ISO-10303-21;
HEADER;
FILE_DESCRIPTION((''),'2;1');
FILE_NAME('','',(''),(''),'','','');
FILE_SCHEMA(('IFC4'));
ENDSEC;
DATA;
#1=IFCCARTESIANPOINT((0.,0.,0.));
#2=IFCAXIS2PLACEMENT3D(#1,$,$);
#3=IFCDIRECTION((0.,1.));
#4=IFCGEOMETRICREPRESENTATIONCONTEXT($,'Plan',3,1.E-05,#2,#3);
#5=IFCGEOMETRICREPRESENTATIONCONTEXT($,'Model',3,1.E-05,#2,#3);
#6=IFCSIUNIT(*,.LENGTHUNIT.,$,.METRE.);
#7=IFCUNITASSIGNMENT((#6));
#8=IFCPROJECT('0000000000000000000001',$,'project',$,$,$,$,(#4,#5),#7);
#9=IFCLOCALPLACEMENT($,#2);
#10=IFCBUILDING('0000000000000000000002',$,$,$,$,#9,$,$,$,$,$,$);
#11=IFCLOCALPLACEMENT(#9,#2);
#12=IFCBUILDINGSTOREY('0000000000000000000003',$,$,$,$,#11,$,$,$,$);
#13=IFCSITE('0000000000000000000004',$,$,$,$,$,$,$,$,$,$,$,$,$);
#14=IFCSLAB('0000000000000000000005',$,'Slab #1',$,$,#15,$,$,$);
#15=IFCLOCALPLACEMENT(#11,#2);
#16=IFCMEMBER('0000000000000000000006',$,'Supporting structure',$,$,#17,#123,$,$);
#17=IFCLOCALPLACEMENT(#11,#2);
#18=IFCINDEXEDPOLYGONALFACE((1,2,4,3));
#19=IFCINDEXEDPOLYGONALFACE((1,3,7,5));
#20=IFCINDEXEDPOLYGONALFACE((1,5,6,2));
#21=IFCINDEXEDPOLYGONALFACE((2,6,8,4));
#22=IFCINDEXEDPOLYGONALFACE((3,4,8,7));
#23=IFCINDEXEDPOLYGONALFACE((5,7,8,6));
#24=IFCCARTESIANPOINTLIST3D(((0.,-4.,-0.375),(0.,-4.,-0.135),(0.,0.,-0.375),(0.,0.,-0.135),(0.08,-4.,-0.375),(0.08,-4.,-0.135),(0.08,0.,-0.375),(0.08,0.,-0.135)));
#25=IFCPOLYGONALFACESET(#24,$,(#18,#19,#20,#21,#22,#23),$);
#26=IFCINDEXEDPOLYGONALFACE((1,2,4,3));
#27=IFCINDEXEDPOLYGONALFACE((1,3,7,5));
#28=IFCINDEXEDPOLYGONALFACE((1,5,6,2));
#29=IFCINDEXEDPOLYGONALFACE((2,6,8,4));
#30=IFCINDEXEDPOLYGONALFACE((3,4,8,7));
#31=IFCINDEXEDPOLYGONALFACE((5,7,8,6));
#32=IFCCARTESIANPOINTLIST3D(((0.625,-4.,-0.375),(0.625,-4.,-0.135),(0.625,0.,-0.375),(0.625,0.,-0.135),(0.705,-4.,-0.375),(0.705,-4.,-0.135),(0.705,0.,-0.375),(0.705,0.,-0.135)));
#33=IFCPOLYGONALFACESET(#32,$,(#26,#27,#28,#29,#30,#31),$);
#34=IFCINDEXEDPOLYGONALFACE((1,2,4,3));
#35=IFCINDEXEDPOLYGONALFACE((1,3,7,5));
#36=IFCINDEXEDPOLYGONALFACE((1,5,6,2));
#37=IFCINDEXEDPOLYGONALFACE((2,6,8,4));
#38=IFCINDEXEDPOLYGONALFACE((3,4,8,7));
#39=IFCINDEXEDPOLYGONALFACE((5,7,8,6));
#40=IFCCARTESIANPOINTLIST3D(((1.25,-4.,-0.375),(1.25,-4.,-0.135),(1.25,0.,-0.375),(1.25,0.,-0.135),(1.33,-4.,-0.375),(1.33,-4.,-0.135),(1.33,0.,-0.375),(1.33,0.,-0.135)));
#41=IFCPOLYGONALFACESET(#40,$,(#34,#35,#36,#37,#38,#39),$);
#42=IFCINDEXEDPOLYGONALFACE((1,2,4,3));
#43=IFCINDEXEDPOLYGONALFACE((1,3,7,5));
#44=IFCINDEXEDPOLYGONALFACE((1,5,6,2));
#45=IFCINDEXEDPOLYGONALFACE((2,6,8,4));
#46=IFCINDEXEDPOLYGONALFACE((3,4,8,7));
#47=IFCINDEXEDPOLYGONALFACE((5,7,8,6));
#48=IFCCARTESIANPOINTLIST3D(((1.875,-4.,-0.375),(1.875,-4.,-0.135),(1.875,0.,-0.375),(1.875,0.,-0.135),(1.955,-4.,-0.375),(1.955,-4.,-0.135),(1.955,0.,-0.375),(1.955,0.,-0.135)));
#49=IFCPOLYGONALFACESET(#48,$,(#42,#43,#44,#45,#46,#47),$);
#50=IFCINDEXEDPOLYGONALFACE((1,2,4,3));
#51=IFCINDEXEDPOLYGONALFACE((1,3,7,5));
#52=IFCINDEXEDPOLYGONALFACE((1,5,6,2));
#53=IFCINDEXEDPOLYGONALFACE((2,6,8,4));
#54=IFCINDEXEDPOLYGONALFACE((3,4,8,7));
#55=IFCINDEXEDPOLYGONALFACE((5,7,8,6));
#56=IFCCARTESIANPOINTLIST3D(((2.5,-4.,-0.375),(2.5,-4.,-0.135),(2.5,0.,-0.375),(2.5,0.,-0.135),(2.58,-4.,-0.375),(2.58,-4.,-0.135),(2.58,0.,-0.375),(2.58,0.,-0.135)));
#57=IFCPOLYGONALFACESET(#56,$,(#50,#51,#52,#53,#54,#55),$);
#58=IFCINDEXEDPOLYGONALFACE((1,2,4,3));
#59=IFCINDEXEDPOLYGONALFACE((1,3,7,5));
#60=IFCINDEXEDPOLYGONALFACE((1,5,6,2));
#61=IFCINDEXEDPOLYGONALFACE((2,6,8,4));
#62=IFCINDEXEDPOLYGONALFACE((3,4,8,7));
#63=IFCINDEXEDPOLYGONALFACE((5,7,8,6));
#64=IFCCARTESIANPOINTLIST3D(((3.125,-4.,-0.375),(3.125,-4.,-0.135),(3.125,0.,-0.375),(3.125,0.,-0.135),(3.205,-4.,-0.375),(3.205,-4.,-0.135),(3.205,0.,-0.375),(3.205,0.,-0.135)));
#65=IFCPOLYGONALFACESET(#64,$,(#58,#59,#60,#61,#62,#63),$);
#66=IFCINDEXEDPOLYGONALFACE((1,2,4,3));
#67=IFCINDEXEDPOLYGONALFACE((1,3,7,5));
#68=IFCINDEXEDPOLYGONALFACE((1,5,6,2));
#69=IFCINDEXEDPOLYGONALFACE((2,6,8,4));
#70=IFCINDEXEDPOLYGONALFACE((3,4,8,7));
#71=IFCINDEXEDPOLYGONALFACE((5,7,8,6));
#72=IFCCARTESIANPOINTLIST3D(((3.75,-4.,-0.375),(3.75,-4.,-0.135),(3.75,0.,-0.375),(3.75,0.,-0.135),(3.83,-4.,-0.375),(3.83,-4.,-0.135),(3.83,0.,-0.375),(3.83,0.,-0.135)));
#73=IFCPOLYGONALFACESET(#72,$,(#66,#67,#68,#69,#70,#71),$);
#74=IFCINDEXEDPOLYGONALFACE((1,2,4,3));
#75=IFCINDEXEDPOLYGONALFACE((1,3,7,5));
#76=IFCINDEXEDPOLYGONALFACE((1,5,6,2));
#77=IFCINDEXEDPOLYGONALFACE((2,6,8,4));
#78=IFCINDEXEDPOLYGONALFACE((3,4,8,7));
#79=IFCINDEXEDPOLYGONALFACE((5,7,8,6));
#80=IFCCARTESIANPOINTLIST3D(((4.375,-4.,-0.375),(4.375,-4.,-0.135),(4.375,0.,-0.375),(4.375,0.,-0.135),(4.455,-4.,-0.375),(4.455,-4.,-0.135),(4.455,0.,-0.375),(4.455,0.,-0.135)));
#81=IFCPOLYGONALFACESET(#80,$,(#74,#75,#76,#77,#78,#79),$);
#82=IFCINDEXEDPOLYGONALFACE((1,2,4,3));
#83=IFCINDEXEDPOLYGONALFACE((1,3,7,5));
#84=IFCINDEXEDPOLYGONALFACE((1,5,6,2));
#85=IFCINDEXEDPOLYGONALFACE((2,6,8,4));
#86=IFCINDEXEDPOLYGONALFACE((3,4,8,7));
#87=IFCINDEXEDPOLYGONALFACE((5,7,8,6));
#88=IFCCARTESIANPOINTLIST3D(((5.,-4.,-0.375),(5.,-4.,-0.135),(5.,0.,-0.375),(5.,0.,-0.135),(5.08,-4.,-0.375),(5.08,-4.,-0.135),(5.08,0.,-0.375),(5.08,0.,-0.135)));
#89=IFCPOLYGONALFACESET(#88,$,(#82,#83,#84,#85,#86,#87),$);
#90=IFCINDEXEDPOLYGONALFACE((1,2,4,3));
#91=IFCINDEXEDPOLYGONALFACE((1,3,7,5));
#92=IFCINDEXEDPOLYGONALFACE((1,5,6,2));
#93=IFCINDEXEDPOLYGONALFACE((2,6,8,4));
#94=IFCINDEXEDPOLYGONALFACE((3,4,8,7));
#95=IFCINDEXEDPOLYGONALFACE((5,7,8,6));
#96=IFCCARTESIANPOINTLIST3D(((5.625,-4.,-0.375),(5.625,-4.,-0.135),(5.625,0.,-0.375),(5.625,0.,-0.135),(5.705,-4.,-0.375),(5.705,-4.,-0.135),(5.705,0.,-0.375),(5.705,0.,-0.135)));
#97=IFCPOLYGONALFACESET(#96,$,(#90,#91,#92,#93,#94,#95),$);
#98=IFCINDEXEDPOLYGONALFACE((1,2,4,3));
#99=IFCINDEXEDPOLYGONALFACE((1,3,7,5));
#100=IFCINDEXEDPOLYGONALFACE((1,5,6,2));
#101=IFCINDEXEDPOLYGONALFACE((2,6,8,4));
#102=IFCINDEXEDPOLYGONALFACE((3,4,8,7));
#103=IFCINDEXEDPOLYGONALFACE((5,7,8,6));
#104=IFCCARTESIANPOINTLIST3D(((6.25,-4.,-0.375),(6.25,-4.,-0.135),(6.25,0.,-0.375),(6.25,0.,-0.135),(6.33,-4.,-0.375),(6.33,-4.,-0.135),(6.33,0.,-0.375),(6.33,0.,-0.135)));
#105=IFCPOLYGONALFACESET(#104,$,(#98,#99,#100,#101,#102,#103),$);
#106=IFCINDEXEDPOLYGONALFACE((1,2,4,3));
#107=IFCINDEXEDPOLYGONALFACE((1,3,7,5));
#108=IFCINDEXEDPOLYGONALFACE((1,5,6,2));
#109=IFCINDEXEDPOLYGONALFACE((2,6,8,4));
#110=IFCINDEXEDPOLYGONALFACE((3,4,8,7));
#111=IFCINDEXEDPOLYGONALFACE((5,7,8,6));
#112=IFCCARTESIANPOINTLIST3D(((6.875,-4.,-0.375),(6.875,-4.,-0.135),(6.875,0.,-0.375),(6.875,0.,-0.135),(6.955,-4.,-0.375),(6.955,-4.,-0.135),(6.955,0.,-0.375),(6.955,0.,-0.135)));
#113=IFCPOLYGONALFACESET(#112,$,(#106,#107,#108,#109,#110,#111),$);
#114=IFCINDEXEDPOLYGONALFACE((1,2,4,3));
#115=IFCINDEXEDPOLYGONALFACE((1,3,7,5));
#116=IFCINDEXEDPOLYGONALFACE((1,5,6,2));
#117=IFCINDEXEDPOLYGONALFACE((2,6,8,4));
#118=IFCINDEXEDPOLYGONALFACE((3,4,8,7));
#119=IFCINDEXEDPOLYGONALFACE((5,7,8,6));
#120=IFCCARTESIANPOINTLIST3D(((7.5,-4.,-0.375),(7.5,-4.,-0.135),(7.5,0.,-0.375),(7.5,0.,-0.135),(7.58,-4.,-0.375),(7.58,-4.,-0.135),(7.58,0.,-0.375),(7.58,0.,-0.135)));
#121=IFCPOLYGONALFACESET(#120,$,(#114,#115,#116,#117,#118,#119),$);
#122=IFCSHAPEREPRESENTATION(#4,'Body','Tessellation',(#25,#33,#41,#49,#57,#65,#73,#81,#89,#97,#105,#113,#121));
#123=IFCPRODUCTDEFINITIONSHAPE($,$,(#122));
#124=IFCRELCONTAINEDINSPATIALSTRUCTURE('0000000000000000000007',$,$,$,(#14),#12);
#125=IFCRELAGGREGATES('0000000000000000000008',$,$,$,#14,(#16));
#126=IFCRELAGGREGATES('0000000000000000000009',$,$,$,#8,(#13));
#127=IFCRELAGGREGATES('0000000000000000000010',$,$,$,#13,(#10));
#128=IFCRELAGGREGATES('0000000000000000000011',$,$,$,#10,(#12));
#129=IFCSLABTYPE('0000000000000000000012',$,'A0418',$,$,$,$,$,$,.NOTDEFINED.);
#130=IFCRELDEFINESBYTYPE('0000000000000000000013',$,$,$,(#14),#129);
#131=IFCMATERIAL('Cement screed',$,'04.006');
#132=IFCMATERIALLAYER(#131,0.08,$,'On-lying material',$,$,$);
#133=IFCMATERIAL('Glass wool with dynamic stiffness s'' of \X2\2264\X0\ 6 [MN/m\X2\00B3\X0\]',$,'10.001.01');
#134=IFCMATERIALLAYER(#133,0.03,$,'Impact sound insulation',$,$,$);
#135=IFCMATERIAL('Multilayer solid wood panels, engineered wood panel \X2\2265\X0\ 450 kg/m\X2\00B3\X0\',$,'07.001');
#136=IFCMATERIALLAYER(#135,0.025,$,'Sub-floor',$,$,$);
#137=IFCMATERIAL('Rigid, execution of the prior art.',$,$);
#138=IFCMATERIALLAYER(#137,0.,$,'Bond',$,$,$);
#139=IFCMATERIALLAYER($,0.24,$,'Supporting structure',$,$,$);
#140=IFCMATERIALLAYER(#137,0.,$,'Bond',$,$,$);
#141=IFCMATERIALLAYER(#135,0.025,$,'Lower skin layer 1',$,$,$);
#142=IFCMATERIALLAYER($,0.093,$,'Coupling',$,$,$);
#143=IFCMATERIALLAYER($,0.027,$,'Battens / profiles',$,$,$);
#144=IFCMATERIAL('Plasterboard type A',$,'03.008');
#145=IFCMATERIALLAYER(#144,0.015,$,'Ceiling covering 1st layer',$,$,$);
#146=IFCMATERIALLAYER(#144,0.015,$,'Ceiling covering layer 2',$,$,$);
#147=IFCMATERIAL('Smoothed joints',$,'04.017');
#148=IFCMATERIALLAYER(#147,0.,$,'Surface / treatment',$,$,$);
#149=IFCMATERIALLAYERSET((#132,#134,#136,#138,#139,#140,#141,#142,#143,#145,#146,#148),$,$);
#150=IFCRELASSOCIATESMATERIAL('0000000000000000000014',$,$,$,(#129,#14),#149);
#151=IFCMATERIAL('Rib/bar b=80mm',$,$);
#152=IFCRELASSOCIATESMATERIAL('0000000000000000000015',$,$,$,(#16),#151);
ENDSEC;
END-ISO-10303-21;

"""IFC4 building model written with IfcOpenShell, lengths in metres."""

from ifc_helpers import new_model, si_unit, direction, frame, frame_2d, origin, place, context, project, spatial, rectangle, extrude, material, layer, layer_set, type_object, element, aggregate, save


model = new_model("IFC4")

# Units and contexts
plan_context = context("Plan", 3, precision=1e-05, world=origin(), true_north=direction((0.0, 1.0)))
model_context = context("Model", 3, precision=1e-05, world=origin(), true_north=direction((0.0, 1.0)))
ifc_project = project(units=[si_unit("LENGTHUNIT", "METRE")], contexts=[plan_context, model_context])

# Site, building, storey
site = spatial("IfcSite", under=ifc_project)
building_placement = place(None, origin())
building = spatial("IfcBuilding", under=site, at=building_placement)
storey_placement = place(building_placement, origin())
storey = spatial("IfcBuildingStorey", under=building, at=storey_placement)

# Slab, member
ifc_material_1 = material(Name="Cement screed", Category="04.006")
ifc_layer_1 = layer(ifc_material_1, 0.08, Name="On-lying material")
ifc_material_2 = material(Name="Glass wool with dynamic stiffness s' of ≤ 6 [MN/m³]", Category="10.001.01")
ifc_layer_2 = layer(ifc_material_2, 0.03, Name="Impact sound insulation")
ifc_material_3 = material(Name="Multilayer solid wood panels, engineered wood panel ≥ 450 kg/m³", Category="07.001")
ifc_layer_3 = layer(ifc_material_3, 0.025, Name="Sub-floor")
ifc_material_4 = material(Name="Rigid, execution of the prior art.")
ifc_layer_4 = layer(ifc_material_4, 0.0, Name="Bond")
ifc_layer_5 = layer(None, 0.24, Name="Supporting structure")
ifc_layer_6 = layer(ifc_material_4, 0.0, Name="Bond")
ifc_layer_7 = layer(ifc_material_3, 0.025, Name="Lower skin layer 1")
ifc_layer_8 = layer(None, 0.093, Name="Coupling")
ifc_layer_9 = layer(None, 0.027, Name="Battens / profiles")
ifc_material_5 = material(Name="Plasterboard type A", Category="03.008")
ifc_layer_10 = layer(ifc_material_5, 0.015, Name="Ceiling covering 1st layer")
ifc_layer_11 = layer(ifc_material_5, 0.015, Name="Ceiling covering layer 2")
ifc_material_6 = material(Name="Smoothed joints", Category="04.017")
ifc_layer_12 = layer(ifc_material_6, 0.0, Name="Surface / treatment")
ifc_layer_set = layer_set([ifc_layer_1, ifc_layer_2, ifc_layer_3, ifc_layer_4, ifc_layer_5, ifc_layer_6, ifc_layer_7, ifc_layer_8, ifc_layer_9, ifc_layer_10, ifc_layer_11, ifc_layer_12])
slab_type = type_object("IfcSlabType", Name="A0418", PredefinedType="NOTDEFINED", material=ifc_layer_set)
slab_placement = place(None, frame((0.0, 0.0, 0.0), z_axis=(0.0, 0.0, -1.0), x_axis=(1.0, 0.0, 0.0)))
slab = element("IfcSlab", 1, at=slab_placement, inside=storey, type_object=slab_type, material=ifc_layer_set, Name="Slab #1")
ifc_material_7 = material(Name="Rib/bar b=80mm")
member_1_placement = place(slab_placement, origin())
member_1 = element("IfcMember", 2, at=member_1_placement, material=ifc_material_7, Name="Supporting structure", context=plan_context, shape_type="SweptSolid", body=[
    extrude(rectangle(XDim=0.08, YDim=0.24, at=frame_2d((0.04, 0.12), x_axis=(1.0, 0.0))), frame((0.0, 4.0, 0.135), z_axis=(0.0, -1.0, 0.0), x_axis=(1.0, 0.0, 0.0)), (0.0, 0.0, 1.0), 4.0),
    extrude(rectangle(XDim=0.08, YDim=0.24, at=frame_2d((0.04, 0.12), x_axis=(1.0, 0.0))), frame((0.625, 4.0, 0.135), z_axis=(0.0, -1.0, 0.0), x_axis=(1.0, 0.0, 0.0)), (0.0, 0.0, 1.0), 4.0),
    extrude(rectangle(XDim=0.08, YDim=0.24, at=frame_2d((0.04, 0.12), x_axis=(1.0, 0.0))), frame((1.25, 4.0, 0.135), z_axis=(0.0, -1.0, 0.0), x_axis=(1.0, 0.0, 0.0)), (0.0, 0.0, 1.0), 4.0),
    extrude(rectangle(XDim=0.08, YDim=0.24, at=frame_2d((0.04, 0.12), x_axis=(1.0, 0.0))), frame((1.875, 4.0, 0.135), z_axis=(0.0, -1.0, 0.0), x_axis=(1.0, 0.0, 0.0)), (0.0, 0.0, 1.0), 4.0),
    extrude(rectangle(XDim=0.08, YDim=0.24, at=frame_2d((0.04, 0.12), x_axis=(1.0, 0.0))), frame((2.5, 4.0, 0.135), z_axis=(0.0, -1.0, 0.0), x_axis=(1.0, 0.0, 0.0)), (0.0, 0.0, 1.0), 4.0),
    extrude(rectangle(XDim=0.08, YDim=0.24, at=frame_2d((0.04, 0.12), x_axis=(1.0, 0.0))), frame((3.125, 4.0, 0.135), z_axis=(0.0, -1.0, 0.0), x_axis=(1.0, 0.0, 0.0)), (0.0, 0.0, 1.0), 4.0),
    extrude(rectangle(XDim=0.08, YDim=0.24, at=frame_2d((0.04, 0.12), x_axis=(1.0, 0.0))), frame((3.75, 4.0, 0.135), z_axis=(0.0, -1.0, 0.0), x_axis=(1.0, 0.0, 0.0)), (0.0, 0.0, 1.0), 4.0),
    extrude(rectangle(XDim=0.08, YDim=0.24, at=frame_2d((0.04, 0.12), x_axis=(1.0, 0.0))), frame((4.375, 4.0, 0.135), z_axis=(0.0, -1.0, 0.0), x_axis=(1.0, 0.0, 0.0)), (0.0, 0.0, 1.0), 4.0),
    extrude(rectangle(XDim=0.08, YDim=0.24, at=frame_2d((0.04, 0.12), x_axis=(1.0, 0.0))), frame((5.0, 4.0, 0.135), z_axis=(0.0, -1.0, 0.0), x_axis=(1.0, 0.0, 0.0)), (0.0, 0.0, 1.0), 4.0),
    extrude(rectangle(XDim=0.08, YDim=0.24, at=frame_2d((0.04, 0.12), x_axis=(1.0, 0.0))), frame((5.625, 4.0, 0.135), z_axis=(0.0, -1.0, 0.0), x_axis=(1.0, 0.0, 0.0)), (0.0, 0.0, 1.0), 4.0),
    extrude(rectangle(XDim=0.08, YDim=0.24, at=frame_2d((0.04, 0.12), x_axis=(1.0, 0.0))), frame((6.25, 4.0, 0.135), z_axis=(0.0, -1.0, 0.0), x_axis=(1.0, 0.0, 0.0)), (0.0, 0.0, 1.0), 4.0),
    extrude(rectangle(XDim=0.08, YDim=0.24, at=frame_2d((0.04, 0.12), x_axis=(1.0, 0.0))), frame((6.875, 4.0, 0.135), z_axis=(0.0, -1.0, 0.0), x_axis=(1.0, 0.0, 0.0)), (0.0, 0.0, 1.0), 4.0),
    extrude(rectangle(XDim=0.08, YDim=0.24, at=frame_2d((0.04, 0.12), x_axis=(1.0, 0.0))), frame((7.5, 4.0, 0.135), z_axis=(0.0, -1.0, 0.0), x_axis=(1.0, 0.0, 0.0)), (0.0, 0.0, 1.0), 4.0),
])
aggregate(slab, [member_1])

save(model, "model.ifc")
